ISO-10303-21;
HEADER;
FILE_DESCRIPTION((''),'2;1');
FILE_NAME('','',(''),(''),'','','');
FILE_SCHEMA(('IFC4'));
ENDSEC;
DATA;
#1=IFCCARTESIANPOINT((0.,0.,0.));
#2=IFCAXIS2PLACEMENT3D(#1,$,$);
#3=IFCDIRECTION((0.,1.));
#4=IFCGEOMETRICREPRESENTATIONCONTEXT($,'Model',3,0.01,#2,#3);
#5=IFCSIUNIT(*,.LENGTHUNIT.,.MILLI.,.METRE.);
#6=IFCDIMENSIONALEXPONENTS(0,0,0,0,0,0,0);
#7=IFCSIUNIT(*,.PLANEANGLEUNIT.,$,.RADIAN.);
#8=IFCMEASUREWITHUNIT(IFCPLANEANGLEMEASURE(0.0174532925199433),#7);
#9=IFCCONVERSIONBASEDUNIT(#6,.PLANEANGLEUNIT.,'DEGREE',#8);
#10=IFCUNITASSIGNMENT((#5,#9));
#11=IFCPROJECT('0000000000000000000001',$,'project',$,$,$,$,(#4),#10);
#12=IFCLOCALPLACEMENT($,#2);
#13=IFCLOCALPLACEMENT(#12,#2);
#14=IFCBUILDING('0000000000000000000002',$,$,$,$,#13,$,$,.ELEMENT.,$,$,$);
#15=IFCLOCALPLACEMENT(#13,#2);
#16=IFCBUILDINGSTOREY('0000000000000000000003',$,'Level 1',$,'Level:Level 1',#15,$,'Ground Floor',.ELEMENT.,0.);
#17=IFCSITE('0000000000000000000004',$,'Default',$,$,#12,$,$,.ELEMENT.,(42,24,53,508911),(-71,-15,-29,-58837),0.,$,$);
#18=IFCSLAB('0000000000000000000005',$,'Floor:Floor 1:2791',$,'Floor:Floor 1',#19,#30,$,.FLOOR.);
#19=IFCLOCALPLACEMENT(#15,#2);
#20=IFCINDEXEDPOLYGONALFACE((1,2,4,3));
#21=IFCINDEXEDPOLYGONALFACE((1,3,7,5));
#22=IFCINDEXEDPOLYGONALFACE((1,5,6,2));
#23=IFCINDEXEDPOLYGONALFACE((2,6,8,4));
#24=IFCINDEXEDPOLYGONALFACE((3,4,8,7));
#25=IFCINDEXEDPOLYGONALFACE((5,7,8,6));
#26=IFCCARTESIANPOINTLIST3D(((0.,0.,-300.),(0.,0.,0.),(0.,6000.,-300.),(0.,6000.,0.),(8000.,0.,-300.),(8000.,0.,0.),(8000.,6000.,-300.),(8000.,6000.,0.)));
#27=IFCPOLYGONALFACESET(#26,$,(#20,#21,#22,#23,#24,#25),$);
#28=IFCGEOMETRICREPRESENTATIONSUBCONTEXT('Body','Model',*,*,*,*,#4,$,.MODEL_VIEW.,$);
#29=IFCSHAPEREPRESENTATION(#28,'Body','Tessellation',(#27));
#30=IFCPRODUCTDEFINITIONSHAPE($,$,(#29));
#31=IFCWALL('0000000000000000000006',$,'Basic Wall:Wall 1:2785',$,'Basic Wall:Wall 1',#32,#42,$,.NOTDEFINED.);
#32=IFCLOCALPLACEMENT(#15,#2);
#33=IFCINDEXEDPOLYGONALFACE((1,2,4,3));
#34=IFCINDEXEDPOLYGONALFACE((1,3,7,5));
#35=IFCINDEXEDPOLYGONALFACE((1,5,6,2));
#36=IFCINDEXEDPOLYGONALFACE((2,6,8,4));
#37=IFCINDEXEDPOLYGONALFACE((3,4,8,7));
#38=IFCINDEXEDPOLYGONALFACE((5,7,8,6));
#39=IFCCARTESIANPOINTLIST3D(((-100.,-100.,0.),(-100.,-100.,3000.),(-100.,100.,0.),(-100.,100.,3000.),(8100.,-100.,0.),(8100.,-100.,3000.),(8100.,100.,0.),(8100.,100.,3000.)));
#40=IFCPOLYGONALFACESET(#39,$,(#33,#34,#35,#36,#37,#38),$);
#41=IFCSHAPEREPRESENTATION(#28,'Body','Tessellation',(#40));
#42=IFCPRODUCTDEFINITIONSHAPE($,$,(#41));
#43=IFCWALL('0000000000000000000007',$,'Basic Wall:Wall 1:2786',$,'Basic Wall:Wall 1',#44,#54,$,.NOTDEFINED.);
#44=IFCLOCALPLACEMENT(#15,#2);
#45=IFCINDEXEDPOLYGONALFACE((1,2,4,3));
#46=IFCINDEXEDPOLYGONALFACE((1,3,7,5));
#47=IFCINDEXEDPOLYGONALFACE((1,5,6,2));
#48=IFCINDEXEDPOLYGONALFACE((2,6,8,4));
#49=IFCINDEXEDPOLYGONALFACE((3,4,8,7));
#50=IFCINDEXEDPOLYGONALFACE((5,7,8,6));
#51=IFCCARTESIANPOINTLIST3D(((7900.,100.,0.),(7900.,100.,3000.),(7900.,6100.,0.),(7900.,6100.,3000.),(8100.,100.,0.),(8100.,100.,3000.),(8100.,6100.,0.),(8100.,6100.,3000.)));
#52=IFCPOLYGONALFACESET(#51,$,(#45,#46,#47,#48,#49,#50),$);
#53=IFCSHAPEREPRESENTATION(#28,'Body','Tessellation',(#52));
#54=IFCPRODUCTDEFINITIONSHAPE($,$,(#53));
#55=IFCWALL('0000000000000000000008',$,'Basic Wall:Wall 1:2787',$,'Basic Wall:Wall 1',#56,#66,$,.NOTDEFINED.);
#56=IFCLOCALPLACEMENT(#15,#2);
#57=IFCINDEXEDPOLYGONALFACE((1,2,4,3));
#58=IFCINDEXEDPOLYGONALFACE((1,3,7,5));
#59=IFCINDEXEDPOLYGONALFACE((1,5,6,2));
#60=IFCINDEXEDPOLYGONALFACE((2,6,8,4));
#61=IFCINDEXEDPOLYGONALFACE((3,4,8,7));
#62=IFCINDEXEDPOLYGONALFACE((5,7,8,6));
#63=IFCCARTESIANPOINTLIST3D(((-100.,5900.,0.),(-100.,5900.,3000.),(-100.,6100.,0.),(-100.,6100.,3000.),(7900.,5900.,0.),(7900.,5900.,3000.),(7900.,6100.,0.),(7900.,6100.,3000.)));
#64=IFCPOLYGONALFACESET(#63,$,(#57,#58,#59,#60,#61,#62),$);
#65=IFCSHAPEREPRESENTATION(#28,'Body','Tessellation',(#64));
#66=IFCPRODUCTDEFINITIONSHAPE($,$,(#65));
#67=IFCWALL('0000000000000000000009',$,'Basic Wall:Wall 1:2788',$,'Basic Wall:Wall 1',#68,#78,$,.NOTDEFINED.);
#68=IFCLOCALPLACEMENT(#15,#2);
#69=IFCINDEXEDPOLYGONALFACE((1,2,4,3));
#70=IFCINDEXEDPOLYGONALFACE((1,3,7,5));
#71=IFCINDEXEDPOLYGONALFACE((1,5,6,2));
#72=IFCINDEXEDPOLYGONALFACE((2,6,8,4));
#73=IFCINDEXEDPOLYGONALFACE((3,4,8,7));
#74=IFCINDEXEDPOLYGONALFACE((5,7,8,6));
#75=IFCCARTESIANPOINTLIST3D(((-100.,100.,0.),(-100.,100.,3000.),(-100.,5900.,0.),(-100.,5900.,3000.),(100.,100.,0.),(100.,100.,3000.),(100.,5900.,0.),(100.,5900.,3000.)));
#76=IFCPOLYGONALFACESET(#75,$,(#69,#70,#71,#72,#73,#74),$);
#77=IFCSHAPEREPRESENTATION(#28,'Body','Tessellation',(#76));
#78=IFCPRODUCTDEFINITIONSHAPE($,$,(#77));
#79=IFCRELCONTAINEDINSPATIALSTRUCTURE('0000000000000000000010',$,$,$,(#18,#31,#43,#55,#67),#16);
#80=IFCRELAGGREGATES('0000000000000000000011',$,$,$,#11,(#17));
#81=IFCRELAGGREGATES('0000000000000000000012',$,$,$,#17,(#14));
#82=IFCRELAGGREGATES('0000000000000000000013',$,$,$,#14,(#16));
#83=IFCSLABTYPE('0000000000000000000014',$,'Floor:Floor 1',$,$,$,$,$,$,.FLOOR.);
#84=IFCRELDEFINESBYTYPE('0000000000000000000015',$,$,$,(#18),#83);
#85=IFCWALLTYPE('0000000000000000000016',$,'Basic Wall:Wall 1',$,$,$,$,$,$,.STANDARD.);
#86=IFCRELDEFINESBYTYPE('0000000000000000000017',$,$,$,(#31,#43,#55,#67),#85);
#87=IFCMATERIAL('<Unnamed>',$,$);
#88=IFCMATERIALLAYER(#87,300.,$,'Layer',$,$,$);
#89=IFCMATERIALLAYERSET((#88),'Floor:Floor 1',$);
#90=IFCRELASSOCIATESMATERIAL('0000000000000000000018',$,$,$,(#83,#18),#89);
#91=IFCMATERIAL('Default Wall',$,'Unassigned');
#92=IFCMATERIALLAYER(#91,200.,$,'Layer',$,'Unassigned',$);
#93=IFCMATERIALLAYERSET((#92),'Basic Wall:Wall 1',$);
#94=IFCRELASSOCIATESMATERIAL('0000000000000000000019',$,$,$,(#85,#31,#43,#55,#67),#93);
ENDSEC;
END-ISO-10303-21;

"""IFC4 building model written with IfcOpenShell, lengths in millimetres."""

from ifc_helpers import new_model, entity, si_unit, converted_unit, direction, frame, frame_2d, origin, origin_2d_with_axis, place, context, subcontext, project, spatial, rectangle, extrude, material, layer, layer_set, layer_usage, type_object, element, save


model = new_model("IFC4")

# Units and contexts
model_context = context("Model", 3, precision=0.01, world=origin(), true_north=direction((0.0, 1.0)))
body_context = subcontext(model_context, "Body", "Model", "MODEL_VIEW")
ifc_project = project(units=[si_unit("LENGTHUNIT", "METRE", prefix="MILLI"), converted_unit("PLANEANGLEUNIT", "DEGREE", entity("IfcPlaneAngleMeasure", 0.0174532925199433), si_unit("PLANEANGLEUNIT", "RADIAN"), dimensions=[0, 0, 0, 0, 0, 0, 0])], contexts=[model_context])

# Site, building, storey
site_placement = place(None, origin())
site = spatial("IfcSite", under=ifc_project, at=site_placement, Name="Default", CompositionType="ELEMENT", RefLatitude=(42, 24, 53, 508911), RefLongitude=(-71, -15, -29, -58837), RefElevation=0.0)
building_placement = place(site_placement, origin())
building = spatial("IfcBuilding", under=site, at=building_placement, CompositionType="ELEMENT")
storey_placement = place(building_placement, origin())
storey = spatial("IfcBuildingStorey", under=building, at=storey_placement, Name="Level 1", ObjectType="Level:Level 1", LongName="Ground Floor", CompositionType="ELEMENT", Elevation=0.0)

# Slab
ifc_material_1 = material(Name="<Unnamed>")
ifc_layer_1 = layer(ifc_material_1, 300.0, Name="Layer")
ifc_layer_set_1 = layer_set([ifc_layer_1], Name="Floor:Floor 1")
ifc_layer_usage_1 = layer_usage(ifc_layer_set_1, "AXIS3", "POSITIVE", 0.0)
slab_type = type_object("IfcSlabType", Name="Floor:Floor 1", PredefinedType="FLOOR", material=ifc_layer_set_1)
slab_placement = place(storey_placement, origin())
element("IfcSlab", 1, at=slab_placement, inside=storey, type_object=slab_type, material=ifc_layer_usage_1, Name="Floor:Floor 1:2791", ObjectType="Floor:Floor 1", PredefinedType="FLOOR", context=body_context, shape_type="SweptSolid", body=[
    extrude(rectangle(XDim=6000.0, YDim=8000.0, at=origin_2d_with_axis()), frame((4000.0, 3000.0, 0.0), z_axis=(0.0, 0.0, -1.0), x_axis=(0.0, 1.0, 0.0)), (0.0, 0.0, 1.0), 300.0),
])

# Walls
ifc_material_2 = material(Name="Default Wall", Category="Unassigned")
ifc_layer_2 = layer(ifc_material_2, 200.0, Name="Layer", Category="Unassigned")
ifc_layer_set_2 = layer_set([ifc_layer_2], Name="Basic Wall:Wall 1")
ifc_layer_usage_2 = layer_usage(ifc_layer_set_2, "AXIS2", "NEGATIVE", 100.0)
wall_type = type_object("IfcWallType", Name="Basic Wall:Wall 1", PredefinedType="STANDARD", material=ifc_layer_set_2)
wall_1_placement = place(storey_placement, frame((-100.0, 0.0, 0.0)))
element("IfcWall", 2, at=wall_1_placement, inside=storey, type_object=wall_type, material=ifc_layer_usage_2, Name="Basic Wall:Wall 1:2785", ObjectType="Basic Wall:Wall 1", PredefinedType="NOTDEFINED", context=body_context, shape_type="SweptSolid", body=[
    extrude(rectangle(XDim=8200.0, YDim=200.0, at=frame_2d((4100.0, 0.0), x_axis=(-1.0, 0.0))), origin(), (0.0, 0.0, 1.0), 3000.0),
])
ifc_layer_usage_3 = layer_usage(ifc_layer_set_2, "AXIS2", "NEGATIVE", 100.0)
wall_2_placement = place(storey_placement, frame((8000.0, 100.0, 0.0), z_axis=(0.0, 0.0, 1.0), x_axis=(0.0, 1.0, 0.0)))
element("IfcWall", 3, at=wall_2_placement, inside=storey, type_object=wall_type, material=ifc_layer_usage_3, Name="Basic Wall:Wall 1:2786", ObjectType="Basic Wall:Wall 1", PredefinedType="NOTDEFINED", context=body_context, shape_type="SweptSolid", body=[
    extrude(rectangle(XDim=6000.0, YDim=200.0, at=frame_2d((3000.0, 0.0), x_axis=(-1.0, 0.0))), origin(), (0.0, 0.0, 1.0), 3000.0),
])
ifc_layer_usage_4 = layer_usage(ifc_layer_set_2, "AXIS2", "NEGATIVE", 100.0)
wall_3_placement = place(storey_placement, frame((7900.0, 6000.0, 0.0), z_axis=(0.0, 0.0, 1.0), x_axis=(-1.0, 0.0, 0.0)))
element("IfcWall", 4, at=wall_3_placement, inside=storey, type_object=wall_type, material=ifc_layer_usage_4, Name="Basic Wall:Wall 1:2787", ObjectType="Basic Wall:Wall 1", PredefinedType="NOTDEFINED", context=body_context, shape_type="SweptSolid", body=[
    extrude(rectangle(XDim=8000.0, YDim=200.0, at=frame_2d((4000.0, 0.0), x_axis=(-1.0, 0.0))), origin(), (0.0, 0.0, 1.0), 3000.0),
])
ifc_layer_usage_5 = layer_usage(ifc_layer_set_2, "AXIS2", "NEGATIVE", 100.0)
wall_4_placement = place(storey_placement, frame((0.0, 5900.0, 0.0), z_axis=(0.0, 0.0, 1.0), x_axis=(0.0, -1.0, 0.0)))
element("IfcWall", 5, at=wall_4_placement, inside=storey, type_object=wall_type, material=ifc_layer_usage_5, Name="Basic Wall:Wall 1:2788", ObjectType="Basic Wall:Wall 1", PredefinedType="NOTDEFINED", context=body_context, shape_type="SweptSolid", body=[
    extrude(rectangle(XDim=5800.0, YDim=200.0, at=frame_2d((2900.0, 0.0), x_axis=(-1.0, 0.0))), origin(), (0.0, 0.0, 1.0), 3000.0),
])

save(model, "model.ifc")
